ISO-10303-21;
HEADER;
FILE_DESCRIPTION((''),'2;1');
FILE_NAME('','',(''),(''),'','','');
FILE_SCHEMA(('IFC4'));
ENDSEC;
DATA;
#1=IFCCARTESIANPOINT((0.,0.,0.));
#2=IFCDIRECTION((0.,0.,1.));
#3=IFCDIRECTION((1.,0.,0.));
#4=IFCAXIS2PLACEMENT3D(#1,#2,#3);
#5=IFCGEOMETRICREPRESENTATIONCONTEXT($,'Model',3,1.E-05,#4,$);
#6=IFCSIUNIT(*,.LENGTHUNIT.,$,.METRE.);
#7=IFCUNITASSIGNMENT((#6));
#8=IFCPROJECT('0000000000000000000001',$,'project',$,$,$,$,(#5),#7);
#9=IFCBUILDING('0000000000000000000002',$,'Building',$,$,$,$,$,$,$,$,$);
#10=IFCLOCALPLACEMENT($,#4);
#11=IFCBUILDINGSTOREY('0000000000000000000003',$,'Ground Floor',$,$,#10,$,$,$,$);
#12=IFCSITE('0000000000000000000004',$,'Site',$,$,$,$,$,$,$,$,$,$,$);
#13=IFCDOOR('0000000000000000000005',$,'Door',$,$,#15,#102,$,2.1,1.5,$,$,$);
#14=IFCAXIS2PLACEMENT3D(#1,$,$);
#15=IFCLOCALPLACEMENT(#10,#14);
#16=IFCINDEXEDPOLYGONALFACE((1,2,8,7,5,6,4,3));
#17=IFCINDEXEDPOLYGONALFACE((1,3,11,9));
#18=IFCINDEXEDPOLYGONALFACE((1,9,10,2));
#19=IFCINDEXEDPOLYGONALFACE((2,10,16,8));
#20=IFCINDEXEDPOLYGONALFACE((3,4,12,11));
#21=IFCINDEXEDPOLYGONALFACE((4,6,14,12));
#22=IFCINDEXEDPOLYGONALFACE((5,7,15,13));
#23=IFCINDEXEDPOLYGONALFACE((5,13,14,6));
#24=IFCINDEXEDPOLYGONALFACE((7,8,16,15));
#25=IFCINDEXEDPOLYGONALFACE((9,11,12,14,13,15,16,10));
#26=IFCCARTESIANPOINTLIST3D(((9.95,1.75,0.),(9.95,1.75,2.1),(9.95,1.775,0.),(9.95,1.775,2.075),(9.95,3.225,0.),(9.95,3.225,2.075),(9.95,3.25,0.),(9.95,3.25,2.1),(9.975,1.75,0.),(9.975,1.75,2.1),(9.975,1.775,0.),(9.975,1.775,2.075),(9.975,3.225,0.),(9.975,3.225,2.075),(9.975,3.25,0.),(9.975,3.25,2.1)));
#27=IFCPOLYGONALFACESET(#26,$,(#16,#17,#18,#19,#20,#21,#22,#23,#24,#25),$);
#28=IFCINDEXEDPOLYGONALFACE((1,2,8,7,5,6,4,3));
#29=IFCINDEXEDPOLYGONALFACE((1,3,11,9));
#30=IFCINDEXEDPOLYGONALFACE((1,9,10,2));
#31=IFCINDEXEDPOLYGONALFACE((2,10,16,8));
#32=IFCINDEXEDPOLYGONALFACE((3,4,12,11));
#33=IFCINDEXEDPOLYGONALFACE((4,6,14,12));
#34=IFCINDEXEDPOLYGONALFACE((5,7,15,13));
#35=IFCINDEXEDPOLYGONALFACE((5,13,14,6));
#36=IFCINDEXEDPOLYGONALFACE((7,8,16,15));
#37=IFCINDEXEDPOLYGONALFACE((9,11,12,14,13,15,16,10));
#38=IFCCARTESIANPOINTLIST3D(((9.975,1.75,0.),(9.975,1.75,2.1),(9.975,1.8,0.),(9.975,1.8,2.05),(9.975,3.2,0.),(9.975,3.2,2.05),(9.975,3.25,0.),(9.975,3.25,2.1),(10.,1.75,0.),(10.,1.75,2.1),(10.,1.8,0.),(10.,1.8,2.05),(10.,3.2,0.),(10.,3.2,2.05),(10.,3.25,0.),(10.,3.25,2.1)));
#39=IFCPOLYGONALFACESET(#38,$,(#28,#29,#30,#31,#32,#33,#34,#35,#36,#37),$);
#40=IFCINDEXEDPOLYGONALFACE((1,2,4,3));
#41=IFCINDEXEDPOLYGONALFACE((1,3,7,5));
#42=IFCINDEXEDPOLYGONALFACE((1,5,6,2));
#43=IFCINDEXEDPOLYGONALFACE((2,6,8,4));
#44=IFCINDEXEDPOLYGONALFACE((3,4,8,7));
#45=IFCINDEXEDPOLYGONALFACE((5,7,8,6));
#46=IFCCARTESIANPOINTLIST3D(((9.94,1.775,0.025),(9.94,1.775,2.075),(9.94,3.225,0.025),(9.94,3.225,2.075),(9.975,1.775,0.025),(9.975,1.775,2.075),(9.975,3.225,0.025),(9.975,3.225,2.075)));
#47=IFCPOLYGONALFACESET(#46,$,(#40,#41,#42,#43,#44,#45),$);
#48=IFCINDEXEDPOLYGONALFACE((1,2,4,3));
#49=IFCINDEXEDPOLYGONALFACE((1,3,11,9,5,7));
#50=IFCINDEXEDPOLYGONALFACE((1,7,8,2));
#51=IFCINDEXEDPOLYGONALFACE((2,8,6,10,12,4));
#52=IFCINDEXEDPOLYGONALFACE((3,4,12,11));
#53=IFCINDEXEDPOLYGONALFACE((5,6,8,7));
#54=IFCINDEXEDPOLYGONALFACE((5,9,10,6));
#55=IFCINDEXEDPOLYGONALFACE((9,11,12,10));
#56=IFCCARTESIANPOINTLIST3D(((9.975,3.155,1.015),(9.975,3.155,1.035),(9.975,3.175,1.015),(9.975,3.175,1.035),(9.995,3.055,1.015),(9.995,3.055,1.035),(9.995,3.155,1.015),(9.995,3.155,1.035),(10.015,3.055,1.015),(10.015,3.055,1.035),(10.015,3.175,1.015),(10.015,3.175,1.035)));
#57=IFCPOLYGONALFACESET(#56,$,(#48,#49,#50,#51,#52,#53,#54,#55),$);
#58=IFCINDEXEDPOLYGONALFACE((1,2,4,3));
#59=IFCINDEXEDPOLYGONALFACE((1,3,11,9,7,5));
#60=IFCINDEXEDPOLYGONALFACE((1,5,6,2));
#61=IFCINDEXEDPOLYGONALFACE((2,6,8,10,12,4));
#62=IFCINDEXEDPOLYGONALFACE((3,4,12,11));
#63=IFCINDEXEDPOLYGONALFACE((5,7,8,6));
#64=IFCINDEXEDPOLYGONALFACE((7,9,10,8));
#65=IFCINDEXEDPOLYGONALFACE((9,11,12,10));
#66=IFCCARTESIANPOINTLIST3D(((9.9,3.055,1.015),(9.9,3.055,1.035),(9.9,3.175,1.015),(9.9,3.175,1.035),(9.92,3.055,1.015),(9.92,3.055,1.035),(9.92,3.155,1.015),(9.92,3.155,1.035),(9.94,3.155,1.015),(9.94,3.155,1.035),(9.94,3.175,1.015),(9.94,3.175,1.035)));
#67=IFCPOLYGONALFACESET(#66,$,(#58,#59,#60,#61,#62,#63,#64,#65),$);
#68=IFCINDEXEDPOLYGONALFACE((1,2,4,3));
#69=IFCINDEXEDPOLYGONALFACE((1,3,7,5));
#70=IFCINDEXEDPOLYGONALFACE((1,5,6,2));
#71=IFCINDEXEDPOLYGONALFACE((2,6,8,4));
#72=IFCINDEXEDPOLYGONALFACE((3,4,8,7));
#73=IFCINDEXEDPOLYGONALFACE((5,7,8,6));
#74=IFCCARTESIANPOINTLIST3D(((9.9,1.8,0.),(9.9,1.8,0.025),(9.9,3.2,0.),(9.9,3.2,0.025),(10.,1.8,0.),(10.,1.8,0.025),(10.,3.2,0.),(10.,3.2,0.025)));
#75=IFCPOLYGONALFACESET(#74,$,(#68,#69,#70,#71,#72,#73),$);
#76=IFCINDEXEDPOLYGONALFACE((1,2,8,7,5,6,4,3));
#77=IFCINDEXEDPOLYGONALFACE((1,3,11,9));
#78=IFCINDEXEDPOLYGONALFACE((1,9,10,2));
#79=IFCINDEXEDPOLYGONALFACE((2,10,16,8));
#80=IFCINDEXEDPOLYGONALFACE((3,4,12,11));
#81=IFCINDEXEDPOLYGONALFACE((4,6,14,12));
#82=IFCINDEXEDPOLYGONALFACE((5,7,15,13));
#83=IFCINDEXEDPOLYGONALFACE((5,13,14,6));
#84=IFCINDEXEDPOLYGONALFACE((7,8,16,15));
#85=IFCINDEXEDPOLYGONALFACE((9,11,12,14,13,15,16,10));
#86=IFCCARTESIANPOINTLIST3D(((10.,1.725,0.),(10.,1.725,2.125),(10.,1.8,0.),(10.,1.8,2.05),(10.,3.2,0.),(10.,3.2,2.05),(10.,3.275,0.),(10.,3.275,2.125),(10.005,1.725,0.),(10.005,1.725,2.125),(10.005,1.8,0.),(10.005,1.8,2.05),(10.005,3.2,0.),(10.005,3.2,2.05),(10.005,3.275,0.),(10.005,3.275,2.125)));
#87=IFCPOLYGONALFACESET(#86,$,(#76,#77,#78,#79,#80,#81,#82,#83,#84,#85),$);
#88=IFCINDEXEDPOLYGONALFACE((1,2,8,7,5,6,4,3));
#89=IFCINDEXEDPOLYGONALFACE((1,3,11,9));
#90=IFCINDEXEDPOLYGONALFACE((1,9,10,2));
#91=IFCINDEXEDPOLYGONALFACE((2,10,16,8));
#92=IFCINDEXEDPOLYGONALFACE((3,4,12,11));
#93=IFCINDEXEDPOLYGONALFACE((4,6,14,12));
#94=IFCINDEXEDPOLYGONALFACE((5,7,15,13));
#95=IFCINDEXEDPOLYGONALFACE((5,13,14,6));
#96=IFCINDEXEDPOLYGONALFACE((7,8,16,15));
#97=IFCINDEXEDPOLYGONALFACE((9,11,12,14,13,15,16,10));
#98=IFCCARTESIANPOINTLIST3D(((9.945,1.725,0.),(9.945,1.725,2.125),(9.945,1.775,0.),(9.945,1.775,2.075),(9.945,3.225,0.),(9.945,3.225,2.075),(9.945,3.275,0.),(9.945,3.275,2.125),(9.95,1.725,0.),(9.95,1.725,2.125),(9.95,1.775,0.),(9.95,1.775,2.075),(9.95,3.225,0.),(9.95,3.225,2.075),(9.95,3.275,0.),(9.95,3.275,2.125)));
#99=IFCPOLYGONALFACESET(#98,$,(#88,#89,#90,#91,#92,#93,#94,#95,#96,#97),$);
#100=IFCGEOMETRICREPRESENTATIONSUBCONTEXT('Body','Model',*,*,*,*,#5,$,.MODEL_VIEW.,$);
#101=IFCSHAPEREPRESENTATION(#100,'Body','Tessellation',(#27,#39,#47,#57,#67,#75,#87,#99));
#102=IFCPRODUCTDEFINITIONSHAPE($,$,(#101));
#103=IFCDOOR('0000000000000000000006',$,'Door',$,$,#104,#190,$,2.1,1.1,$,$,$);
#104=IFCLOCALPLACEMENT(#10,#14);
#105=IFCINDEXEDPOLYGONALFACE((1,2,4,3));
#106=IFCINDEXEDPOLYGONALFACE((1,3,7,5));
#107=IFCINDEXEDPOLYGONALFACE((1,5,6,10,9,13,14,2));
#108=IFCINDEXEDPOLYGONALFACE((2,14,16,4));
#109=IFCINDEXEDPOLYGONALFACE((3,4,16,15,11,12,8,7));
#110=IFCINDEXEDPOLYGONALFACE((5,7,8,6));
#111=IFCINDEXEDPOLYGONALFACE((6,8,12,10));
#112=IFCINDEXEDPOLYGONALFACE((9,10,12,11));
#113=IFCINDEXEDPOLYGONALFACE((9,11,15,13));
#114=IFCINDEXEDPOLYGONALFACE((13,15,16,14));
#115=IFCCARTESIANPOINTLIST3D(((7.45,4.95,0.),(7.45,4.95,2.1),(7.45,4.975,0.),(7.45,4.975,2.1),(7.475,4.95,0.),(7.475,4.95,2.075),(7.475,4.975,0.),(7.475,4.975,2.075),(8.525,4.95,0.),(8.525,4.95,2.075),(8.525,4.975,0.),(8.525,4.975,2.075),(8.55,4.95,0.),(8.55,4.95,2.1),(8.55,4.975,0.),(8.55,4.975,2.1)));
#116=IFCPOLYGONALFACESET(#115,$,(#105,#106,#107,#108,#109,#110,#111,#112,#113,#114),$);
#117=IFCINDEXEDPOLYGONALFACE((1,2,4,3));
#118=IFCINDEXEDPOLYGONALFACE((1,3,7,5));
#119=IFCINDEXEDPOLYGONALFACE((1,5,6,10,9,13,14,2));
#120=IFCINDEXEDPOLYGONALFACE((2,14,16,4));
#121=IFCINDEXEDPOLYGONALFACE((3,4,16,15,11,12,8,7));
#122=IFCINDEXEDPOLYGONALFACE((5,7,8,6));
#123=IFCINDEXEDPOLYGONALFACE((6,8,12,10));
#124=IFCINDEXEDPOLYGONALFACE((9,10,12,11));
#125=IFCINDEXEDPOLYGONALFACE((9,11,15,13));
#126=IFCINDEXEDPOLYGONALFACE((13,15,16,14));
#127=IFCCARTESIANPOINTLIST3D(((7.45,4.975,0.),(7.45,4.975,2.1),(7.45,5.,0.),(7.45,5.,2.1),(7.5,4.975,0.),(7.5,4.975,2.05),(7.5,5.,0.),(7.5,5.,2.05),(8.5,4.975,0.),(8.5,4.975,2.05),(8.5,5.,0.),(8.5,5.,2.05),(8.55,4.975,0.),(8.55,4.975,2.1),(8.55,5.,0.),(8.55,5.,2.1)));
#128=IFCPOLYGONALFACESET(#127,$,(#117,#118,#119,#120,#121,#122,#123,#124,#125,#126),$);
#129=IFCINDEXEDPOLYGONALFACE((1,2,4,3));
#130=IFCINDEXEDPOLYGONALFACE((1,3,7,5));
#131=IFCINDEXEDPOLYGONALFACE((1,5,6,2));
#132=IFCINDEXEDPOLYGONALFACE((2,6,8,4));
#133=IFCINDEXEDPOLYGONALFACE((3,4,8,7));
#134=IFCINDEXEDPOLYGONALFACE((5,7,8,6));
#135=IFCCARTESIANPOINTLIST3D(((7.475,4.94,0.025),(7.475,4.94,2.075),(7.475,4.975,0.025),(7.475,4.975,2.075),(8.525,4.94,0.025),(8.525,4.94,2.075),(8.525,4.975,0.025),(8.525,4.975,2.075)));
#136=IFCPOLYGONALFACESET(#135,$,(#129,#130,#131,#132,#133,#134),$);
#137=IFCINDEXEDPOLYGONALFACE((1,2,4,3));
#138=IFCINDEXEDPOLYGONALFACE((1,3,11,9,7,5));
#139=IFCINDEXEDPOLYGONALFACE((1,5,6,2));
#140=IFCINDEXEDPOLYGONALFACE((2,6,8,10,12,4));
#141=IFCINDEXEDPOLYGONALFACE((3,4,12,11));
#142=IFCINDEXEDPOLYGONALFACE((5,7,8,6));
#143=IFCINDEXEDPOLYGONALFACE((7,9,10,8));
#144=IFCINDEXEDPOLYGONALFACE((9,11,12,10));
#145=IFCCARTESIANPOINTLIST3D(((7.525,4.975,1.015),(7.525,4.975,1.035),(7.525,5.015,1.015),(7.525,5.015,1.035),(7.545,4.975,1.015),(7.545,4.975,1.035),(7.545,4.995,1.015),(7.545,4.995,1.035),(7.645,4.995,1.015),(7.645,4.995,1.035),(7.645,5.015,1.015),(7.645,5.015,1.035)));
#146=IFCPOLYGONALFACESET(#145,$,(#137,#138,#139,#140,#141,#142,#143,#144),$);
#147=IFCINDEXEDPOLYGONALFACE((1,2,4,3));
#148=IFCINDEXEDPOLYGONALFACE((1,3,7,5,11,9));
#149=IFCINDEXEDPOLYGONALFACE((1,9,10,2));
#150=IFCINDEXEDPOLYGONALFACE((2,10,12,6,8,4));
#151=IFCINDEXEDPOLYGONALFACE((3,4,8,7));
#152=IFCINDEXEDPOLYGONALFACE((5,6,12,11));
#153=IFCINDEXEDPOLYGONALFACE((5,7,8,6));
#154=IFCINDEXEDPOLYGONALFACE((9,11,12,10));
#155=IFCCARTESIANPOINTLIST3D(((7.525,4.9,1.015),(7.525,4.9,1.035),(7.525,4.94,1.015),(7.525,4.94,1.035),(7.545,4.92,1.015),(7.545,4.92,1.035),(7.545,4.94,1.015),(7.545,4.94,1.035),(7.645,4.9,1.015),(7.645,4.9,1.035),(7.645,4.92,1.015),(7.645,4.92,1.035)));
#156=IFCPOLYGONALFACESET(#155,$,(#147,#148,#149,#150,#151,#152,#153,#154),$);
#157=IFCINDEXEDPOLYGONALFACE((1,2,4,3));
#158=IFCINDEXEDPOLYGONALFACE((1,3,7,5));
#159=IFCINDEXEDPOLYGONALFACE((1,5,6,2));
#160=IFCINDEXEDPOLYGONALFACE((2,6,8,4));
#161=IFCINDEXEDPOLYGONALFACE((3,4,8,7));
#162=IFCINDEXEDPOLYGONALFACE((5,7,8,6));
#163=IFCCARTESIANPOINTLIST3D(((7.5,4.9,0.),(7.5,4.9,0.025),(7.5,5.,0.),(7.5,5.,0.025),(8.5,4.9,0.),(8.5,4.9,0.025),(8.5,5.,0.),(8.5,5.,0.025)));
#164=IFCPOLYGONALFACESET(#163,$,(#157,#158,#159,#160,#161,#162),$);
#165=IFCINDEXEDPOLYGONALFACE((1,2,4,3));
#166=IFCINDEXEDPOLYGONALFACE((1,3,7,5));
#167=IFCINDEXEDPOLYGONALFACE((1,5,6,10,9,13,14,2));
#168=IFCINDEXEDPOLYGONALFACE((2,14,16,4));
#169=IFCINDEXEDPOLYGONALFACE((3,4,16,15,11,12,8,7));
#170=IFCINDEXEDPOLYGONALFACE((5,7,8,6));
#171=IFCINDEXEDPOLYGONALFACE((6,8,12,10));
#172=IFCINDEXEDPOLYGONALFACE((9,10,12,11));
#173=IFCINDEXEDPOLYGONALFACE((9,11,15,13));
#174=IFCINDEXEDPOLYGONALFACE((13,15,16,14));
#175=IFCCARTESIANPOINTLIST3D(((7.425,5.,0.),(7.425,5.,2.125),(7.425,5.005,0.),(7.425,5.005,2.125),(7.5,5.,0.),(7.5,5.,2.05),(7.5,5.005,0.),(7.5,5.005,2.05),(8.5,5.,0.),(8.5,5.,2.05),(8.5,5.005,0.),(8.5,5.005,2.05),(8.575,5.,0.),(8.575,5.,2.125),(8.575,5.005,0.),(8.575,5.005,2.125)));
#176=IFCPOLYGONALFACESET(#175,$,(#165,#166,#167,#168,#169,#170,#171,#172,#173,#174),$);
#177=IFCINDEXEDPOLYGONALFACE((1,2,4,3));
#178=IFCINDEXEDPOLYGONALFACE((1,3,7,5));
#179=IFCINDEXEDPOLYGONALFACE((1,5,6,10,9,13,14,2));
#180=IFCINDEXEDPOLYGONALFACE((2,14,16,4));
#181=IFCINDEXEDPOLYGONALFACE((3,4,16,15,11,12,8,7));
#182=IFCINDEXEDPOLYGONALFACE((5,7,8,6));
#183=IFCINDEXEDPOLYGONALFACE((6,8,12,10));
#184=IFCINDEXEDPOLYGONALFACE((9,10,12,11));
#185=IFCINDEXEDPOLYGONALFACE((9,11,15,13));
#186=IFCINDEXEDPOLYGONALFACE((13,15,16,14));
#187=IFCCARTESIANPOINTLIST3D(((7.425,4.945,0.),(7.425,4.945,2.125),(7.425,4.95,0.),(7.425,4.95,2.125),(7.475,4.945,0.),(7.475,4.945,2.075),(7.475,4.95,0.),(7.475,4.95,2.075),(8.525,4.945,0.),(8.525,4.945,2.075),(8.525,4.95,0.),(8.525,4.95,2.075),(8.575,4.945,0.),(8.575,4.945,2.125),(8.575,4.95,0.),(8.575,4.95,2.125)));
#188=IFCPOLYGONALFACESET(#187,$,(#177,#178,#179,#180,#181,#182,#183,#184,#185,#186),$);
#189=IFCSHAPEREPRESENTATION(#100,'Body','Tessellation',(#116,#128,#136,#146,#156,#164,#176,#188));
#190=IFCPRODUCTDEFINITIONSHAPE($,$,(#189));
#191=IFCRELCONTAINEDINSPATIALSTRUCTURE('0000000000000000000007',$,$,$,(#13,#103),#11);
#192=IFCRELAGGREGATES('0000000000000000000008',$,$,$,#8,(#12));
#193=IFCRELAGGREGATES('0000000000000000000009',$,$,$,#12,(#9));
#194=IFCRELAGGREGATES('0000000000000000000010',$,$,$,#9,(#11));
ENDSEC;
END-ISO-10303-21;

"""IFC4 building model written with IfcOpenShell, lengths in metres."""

from ifc_helpers import new_model, si_unit, frame, origin_with_axes, place, context, subcontext, project, spatial, line, indexed_curve, outline, extrude, element, save


model = new_model("IFC4")

# Units and contexts
model_context = context("Model", 3, precision=1e-05, world=origin_with_axes())
body_context = subcontext(model_context, "Body", "Model", "MODEL_VIEW")
ifc_project = project(units=[si_unit("LENGTHUNIT", "METRE")], contexts=[model_context])

# Site, building, storey
site = spatial("IfcSite", under=ifc_project, Name="Site")
building = spatial("IfcBuilding", under=site, Name="Building")
storey_placement = place(None, origin_with_axes())
storey = spatial("IfcBuildingStorey", under=building, at=storey_placement, Name="Ground Floor")

# Doors
door_1_placement = place(storey_placement, frame((10.0, 1.75, 0.0), z_axis=(0.0, 0.0, 1.0), x_axis=(0.0, 1.0, 0.0)))
element("IfcDoor", 1, at=door_1_placement, inside=storey, Name="Door", OverallHeight=2.1, OverallWidth=1.5, context=body_context, shape_type="SweptSolid", body=[
    extrude(outline(indexed_curve([(0.0, 0.0), (0.0, 2.1), (1.5, 2.1), (1.5, 0.0), (1.475, 0.0), (1.475, 2.075), (0.025, 2.075), (0.025, 0.0)], segments=[line(1, 2, 3, 4, 5, 6, 7, 8, 1)])), frame((0.0, 0.025, 0.0), z_axis=(0.0, -1.0, 0.0), x_axis=(1.0, 0.0, 0.0)), (0.0, 0.0, -1.0), 0.025),
    extrude(outline(indexed_curve([(0.0, 0.0), (0.0, 2.1), (1.5, 2.1), (1.5, 0.0), (1.45, 0.0), (1.45, 2.05), (0.05, 2.05), (0.05, 0.0)], segments=[line(1, 2, 3, 4, 5, 6, 7, 8, 1)])), frame((0.0, 0.0, 0.0), z_axis=(0.0, -1.0, 0.0), x_axis=(1.0, 0.0, 0.0)), (0.0, 0.0, -1.0), 0.025),
    extrude(outline(indexed_curve([(0.0, 0.0), (1.45, 0.0), (1.45, 0.035), (0.0, 0.035)], segments=[line(1, 2, 3, 4, 1)])), frame((0.025, 0.025, 0.025), z_axis=(0.0, 0.0, 1.0), x_axis=(1.0, 0.0, 0.0)), (0.0, 0.0, 1.0), 2.05),
    extrude(outline(indexed_curve([(0.0, 0.0), (0.0, -0.04), (-0.12, -0.04), (-0.12, -0.02), (-0.02, -0.02), (-0.02, 0.0)], segments=[line(1, 2, 3, 4, 5, 6, 1)])), frame((1.425, 0.025, 1.015), z_axis=(0.0, 0.0, 1.0), x_axis=(1.0, 0.0, 0.0)), (0.0, 0.0, 1.0), 0.02),
    extrude(outline(indexed_curve([(0.0, 0.0), (0.0, 0.04), (-0.12, 0.04), (-0.12, 0.02), (-0.02, 0.02), (-0.02, 0.0)], segments=[line(1, 2, 3, 4, 5, 6, 1)])), frame((1.425, 0.06, 1.015), z_axis=(0.0, 0.0, 1.0), x_axis=(1.0, 0.0, 0.0)), (0.0, 0.0, 1.0), 0.02),
    extrude(outline(indexed_curve([(0.0, 0.0), (1.4, 0.0), (1.4, 0.1), (0.0, 0.1)], segments=[line(1, 2, 3, 4, 1)])), frame((0.05, 0.0, 0.0), z_axis=(0.0, 0.0, 1.0), x_axis=(1.0, 0.0, 0.0)), (0.0, 0.0, 1.0), 0.025),
    extrude(outline(indexed_curve([(0.0, 0.0), (0.0, 2.125), (1.55, 2.125), (1.55, 0.0), (1.475, 0.0), (1.475, 2.05), (0.075, 2.05), (0.075, 0.0)], segments=[line(1, 2, 3, 4, 5, 6, 7, 8, 1)])), frame((-0.025, -0.005, 0.0), z_axis=(0.0, -1.0, 0.0), x_axis=(1.0, 0.0, 0.0)), (0.0, 0.0, -1.0), 0.005),
    extrude(outline(indexed_curve([(0.0, 0.0), (0.0, 2.125), (1.55, 2.125), (1.55, 0.0), (1.5, 0.0), (1.5, 2.075), (0.05, 2.075), (0.05, 0.0)], segments=[line(1, 2, 3, 4, 5, 6, 7, 8, 1)])), frame((-0.025, 0.05, 0.0), z_axis=(0.0, -1.0, 0.0), x_axis=(1.0, 0.0, 0.0)), (0.0, 0.0, -1.0), 0.005),
])
door_2_placement = place(storey_placement, frame((8.55, 5.0, 0.0), z_axis=(0.0, 0.0, 1.0), x_axis=(-1.0, 0.0, 0.0)))
element("IfcDoor", 2, at=door_2_placement, inside=storey, Name="Door", OverallHeight=2.1, OverallWidth=1.1, context=body_context, shape_type="SweptSolid", body=[
    extrude(outline(indexed_curve([(0.0, 0.0), (0.0, 2.1), (1.1, 2.1), (1.1, 0.0), (1.075, 0.0), (1.075, 2.075), (0.025, 2.075), (0.025, 0.0)], segments=[line(1, 2, 3, 4, 5, 6, 7, 8, 1)])), frame((0.0, 0.025, 0.0), z_axis=(0.0, -1.0, 0.0), x_axis=(1.0, 0.0, 0.0)), (0.0, 0.0, -1.0), 0.025),
    extrude(outline(indexed_curve([(0.0, 0.0), (0.0, 2.1), (1.1, 2.1), (1.1, 0.0), (1.05, 0.0), (1.05, 2.05), (0.05, 2.05), (0.05, 0.0)], segments=[line(1, 2, 3, 4, 5, 6, 7, 8, 1)])), frame((0.0, 0.0, 0.0), z_axis=(0.0, -1.0, 0.0), x_axis=(1.0, 0.0, 0.0)), (0.0, 0.0, -1.0), 0.025),
    extrude(outline(indexed_curve([(0.0, 0.0), (1.05, 0.0), (1.05, 0.035), (0.0, 0.035)], segments=[line(1, 2, 3, 4, 1)])), frame((0.025, 0.025, 0.025), z_axis=(0.0, 0.0, 1.0), x_axis=(1.0, 0.0, 0.0)), (0.0, 0.0, 1.0), 2.05),
    extrude(outline(indexed_curve([(0.0, 0.0), (0.0, -0.04), (-0.12, -0.04), (-0.12, -0.02), (-0.02, -0.02), (-0.02, 0.0)], segments=[line(1, 2, 3, 4, 5, 6, 1)])), frame((1.025, 0.025, 1.015), z_axis=(0.0, 0.0, 1.0), x_axis=(1.0, 0.0, 0.0)), (0.0, 0.0, 1.0), 0.02),
    extrude(outline(indexed_curve([(0.0, 0.0), (0.0, 0.04), (-0.12, 0.04), (-0.12, 0.02), (-0.02, 0.02), (-0.02, 0.0)], segments=[line(1, 2, 3, 4, 5, 6, 1)])), frame((1.025, 0.06, 1.015), z_axis=(0.0, 0.0, 1.0), x_axis=(1.0, 0.0, 0.0)), (0.0, 0.0, 1.0), 0.02),
    extrude(outline(indexed_curve([(0.0, 0.0), (1.0, 0.0), (1.0, 0.1), (0.0, 0.1)], segments=[line(1, 2, 3, 4, 1)])), frame((0.05, 0.0, 0.0), z_axis=(0.0, 0.0, 1.0), x_axis=(1.0, 0.0, 0.0)), (0.0, 0.0, 1.0), 0.025),
    extrude(outline(indexed_curve([(0.0, 0.0), (0.0, 2.125), (1.15, 2.125), (1.15, 0.0), (1.075, 0.0), (1.075, 2.05), (0.075, 2.05), (0.075, 0.0)], segments=[line(1, 2, 3, 4, 5, 6, 7, 8, 1)])), frame((-0.025, -0.005, 0.0), z_axis=(0.0, -1.0, 0.0), x_axis=(1.0, 0.0, 0.0)), (0.0, 0.0, -1.0), 0.005),
    extrude(outline(indexed_curve([(0.0, 0.0), (0.0, 2.125), (1.15, 2.125), (1.15, 0.0), (1.1, 0.0), (1.1, 2.075), (0.05, 2.075), (0.05, 0.0)], segments=[line(1, 2, 3, 4, 5, 6, 7, 8, 1)])), frame((-0.025, 0.05, 0.0), z_axis=(0.0, -1.0, 0.0), x_axis=(1.0, 0.0, 0.0)), (0.0, 0.0, -1.0), 0.005),
])

save(model, "model.ifc")
